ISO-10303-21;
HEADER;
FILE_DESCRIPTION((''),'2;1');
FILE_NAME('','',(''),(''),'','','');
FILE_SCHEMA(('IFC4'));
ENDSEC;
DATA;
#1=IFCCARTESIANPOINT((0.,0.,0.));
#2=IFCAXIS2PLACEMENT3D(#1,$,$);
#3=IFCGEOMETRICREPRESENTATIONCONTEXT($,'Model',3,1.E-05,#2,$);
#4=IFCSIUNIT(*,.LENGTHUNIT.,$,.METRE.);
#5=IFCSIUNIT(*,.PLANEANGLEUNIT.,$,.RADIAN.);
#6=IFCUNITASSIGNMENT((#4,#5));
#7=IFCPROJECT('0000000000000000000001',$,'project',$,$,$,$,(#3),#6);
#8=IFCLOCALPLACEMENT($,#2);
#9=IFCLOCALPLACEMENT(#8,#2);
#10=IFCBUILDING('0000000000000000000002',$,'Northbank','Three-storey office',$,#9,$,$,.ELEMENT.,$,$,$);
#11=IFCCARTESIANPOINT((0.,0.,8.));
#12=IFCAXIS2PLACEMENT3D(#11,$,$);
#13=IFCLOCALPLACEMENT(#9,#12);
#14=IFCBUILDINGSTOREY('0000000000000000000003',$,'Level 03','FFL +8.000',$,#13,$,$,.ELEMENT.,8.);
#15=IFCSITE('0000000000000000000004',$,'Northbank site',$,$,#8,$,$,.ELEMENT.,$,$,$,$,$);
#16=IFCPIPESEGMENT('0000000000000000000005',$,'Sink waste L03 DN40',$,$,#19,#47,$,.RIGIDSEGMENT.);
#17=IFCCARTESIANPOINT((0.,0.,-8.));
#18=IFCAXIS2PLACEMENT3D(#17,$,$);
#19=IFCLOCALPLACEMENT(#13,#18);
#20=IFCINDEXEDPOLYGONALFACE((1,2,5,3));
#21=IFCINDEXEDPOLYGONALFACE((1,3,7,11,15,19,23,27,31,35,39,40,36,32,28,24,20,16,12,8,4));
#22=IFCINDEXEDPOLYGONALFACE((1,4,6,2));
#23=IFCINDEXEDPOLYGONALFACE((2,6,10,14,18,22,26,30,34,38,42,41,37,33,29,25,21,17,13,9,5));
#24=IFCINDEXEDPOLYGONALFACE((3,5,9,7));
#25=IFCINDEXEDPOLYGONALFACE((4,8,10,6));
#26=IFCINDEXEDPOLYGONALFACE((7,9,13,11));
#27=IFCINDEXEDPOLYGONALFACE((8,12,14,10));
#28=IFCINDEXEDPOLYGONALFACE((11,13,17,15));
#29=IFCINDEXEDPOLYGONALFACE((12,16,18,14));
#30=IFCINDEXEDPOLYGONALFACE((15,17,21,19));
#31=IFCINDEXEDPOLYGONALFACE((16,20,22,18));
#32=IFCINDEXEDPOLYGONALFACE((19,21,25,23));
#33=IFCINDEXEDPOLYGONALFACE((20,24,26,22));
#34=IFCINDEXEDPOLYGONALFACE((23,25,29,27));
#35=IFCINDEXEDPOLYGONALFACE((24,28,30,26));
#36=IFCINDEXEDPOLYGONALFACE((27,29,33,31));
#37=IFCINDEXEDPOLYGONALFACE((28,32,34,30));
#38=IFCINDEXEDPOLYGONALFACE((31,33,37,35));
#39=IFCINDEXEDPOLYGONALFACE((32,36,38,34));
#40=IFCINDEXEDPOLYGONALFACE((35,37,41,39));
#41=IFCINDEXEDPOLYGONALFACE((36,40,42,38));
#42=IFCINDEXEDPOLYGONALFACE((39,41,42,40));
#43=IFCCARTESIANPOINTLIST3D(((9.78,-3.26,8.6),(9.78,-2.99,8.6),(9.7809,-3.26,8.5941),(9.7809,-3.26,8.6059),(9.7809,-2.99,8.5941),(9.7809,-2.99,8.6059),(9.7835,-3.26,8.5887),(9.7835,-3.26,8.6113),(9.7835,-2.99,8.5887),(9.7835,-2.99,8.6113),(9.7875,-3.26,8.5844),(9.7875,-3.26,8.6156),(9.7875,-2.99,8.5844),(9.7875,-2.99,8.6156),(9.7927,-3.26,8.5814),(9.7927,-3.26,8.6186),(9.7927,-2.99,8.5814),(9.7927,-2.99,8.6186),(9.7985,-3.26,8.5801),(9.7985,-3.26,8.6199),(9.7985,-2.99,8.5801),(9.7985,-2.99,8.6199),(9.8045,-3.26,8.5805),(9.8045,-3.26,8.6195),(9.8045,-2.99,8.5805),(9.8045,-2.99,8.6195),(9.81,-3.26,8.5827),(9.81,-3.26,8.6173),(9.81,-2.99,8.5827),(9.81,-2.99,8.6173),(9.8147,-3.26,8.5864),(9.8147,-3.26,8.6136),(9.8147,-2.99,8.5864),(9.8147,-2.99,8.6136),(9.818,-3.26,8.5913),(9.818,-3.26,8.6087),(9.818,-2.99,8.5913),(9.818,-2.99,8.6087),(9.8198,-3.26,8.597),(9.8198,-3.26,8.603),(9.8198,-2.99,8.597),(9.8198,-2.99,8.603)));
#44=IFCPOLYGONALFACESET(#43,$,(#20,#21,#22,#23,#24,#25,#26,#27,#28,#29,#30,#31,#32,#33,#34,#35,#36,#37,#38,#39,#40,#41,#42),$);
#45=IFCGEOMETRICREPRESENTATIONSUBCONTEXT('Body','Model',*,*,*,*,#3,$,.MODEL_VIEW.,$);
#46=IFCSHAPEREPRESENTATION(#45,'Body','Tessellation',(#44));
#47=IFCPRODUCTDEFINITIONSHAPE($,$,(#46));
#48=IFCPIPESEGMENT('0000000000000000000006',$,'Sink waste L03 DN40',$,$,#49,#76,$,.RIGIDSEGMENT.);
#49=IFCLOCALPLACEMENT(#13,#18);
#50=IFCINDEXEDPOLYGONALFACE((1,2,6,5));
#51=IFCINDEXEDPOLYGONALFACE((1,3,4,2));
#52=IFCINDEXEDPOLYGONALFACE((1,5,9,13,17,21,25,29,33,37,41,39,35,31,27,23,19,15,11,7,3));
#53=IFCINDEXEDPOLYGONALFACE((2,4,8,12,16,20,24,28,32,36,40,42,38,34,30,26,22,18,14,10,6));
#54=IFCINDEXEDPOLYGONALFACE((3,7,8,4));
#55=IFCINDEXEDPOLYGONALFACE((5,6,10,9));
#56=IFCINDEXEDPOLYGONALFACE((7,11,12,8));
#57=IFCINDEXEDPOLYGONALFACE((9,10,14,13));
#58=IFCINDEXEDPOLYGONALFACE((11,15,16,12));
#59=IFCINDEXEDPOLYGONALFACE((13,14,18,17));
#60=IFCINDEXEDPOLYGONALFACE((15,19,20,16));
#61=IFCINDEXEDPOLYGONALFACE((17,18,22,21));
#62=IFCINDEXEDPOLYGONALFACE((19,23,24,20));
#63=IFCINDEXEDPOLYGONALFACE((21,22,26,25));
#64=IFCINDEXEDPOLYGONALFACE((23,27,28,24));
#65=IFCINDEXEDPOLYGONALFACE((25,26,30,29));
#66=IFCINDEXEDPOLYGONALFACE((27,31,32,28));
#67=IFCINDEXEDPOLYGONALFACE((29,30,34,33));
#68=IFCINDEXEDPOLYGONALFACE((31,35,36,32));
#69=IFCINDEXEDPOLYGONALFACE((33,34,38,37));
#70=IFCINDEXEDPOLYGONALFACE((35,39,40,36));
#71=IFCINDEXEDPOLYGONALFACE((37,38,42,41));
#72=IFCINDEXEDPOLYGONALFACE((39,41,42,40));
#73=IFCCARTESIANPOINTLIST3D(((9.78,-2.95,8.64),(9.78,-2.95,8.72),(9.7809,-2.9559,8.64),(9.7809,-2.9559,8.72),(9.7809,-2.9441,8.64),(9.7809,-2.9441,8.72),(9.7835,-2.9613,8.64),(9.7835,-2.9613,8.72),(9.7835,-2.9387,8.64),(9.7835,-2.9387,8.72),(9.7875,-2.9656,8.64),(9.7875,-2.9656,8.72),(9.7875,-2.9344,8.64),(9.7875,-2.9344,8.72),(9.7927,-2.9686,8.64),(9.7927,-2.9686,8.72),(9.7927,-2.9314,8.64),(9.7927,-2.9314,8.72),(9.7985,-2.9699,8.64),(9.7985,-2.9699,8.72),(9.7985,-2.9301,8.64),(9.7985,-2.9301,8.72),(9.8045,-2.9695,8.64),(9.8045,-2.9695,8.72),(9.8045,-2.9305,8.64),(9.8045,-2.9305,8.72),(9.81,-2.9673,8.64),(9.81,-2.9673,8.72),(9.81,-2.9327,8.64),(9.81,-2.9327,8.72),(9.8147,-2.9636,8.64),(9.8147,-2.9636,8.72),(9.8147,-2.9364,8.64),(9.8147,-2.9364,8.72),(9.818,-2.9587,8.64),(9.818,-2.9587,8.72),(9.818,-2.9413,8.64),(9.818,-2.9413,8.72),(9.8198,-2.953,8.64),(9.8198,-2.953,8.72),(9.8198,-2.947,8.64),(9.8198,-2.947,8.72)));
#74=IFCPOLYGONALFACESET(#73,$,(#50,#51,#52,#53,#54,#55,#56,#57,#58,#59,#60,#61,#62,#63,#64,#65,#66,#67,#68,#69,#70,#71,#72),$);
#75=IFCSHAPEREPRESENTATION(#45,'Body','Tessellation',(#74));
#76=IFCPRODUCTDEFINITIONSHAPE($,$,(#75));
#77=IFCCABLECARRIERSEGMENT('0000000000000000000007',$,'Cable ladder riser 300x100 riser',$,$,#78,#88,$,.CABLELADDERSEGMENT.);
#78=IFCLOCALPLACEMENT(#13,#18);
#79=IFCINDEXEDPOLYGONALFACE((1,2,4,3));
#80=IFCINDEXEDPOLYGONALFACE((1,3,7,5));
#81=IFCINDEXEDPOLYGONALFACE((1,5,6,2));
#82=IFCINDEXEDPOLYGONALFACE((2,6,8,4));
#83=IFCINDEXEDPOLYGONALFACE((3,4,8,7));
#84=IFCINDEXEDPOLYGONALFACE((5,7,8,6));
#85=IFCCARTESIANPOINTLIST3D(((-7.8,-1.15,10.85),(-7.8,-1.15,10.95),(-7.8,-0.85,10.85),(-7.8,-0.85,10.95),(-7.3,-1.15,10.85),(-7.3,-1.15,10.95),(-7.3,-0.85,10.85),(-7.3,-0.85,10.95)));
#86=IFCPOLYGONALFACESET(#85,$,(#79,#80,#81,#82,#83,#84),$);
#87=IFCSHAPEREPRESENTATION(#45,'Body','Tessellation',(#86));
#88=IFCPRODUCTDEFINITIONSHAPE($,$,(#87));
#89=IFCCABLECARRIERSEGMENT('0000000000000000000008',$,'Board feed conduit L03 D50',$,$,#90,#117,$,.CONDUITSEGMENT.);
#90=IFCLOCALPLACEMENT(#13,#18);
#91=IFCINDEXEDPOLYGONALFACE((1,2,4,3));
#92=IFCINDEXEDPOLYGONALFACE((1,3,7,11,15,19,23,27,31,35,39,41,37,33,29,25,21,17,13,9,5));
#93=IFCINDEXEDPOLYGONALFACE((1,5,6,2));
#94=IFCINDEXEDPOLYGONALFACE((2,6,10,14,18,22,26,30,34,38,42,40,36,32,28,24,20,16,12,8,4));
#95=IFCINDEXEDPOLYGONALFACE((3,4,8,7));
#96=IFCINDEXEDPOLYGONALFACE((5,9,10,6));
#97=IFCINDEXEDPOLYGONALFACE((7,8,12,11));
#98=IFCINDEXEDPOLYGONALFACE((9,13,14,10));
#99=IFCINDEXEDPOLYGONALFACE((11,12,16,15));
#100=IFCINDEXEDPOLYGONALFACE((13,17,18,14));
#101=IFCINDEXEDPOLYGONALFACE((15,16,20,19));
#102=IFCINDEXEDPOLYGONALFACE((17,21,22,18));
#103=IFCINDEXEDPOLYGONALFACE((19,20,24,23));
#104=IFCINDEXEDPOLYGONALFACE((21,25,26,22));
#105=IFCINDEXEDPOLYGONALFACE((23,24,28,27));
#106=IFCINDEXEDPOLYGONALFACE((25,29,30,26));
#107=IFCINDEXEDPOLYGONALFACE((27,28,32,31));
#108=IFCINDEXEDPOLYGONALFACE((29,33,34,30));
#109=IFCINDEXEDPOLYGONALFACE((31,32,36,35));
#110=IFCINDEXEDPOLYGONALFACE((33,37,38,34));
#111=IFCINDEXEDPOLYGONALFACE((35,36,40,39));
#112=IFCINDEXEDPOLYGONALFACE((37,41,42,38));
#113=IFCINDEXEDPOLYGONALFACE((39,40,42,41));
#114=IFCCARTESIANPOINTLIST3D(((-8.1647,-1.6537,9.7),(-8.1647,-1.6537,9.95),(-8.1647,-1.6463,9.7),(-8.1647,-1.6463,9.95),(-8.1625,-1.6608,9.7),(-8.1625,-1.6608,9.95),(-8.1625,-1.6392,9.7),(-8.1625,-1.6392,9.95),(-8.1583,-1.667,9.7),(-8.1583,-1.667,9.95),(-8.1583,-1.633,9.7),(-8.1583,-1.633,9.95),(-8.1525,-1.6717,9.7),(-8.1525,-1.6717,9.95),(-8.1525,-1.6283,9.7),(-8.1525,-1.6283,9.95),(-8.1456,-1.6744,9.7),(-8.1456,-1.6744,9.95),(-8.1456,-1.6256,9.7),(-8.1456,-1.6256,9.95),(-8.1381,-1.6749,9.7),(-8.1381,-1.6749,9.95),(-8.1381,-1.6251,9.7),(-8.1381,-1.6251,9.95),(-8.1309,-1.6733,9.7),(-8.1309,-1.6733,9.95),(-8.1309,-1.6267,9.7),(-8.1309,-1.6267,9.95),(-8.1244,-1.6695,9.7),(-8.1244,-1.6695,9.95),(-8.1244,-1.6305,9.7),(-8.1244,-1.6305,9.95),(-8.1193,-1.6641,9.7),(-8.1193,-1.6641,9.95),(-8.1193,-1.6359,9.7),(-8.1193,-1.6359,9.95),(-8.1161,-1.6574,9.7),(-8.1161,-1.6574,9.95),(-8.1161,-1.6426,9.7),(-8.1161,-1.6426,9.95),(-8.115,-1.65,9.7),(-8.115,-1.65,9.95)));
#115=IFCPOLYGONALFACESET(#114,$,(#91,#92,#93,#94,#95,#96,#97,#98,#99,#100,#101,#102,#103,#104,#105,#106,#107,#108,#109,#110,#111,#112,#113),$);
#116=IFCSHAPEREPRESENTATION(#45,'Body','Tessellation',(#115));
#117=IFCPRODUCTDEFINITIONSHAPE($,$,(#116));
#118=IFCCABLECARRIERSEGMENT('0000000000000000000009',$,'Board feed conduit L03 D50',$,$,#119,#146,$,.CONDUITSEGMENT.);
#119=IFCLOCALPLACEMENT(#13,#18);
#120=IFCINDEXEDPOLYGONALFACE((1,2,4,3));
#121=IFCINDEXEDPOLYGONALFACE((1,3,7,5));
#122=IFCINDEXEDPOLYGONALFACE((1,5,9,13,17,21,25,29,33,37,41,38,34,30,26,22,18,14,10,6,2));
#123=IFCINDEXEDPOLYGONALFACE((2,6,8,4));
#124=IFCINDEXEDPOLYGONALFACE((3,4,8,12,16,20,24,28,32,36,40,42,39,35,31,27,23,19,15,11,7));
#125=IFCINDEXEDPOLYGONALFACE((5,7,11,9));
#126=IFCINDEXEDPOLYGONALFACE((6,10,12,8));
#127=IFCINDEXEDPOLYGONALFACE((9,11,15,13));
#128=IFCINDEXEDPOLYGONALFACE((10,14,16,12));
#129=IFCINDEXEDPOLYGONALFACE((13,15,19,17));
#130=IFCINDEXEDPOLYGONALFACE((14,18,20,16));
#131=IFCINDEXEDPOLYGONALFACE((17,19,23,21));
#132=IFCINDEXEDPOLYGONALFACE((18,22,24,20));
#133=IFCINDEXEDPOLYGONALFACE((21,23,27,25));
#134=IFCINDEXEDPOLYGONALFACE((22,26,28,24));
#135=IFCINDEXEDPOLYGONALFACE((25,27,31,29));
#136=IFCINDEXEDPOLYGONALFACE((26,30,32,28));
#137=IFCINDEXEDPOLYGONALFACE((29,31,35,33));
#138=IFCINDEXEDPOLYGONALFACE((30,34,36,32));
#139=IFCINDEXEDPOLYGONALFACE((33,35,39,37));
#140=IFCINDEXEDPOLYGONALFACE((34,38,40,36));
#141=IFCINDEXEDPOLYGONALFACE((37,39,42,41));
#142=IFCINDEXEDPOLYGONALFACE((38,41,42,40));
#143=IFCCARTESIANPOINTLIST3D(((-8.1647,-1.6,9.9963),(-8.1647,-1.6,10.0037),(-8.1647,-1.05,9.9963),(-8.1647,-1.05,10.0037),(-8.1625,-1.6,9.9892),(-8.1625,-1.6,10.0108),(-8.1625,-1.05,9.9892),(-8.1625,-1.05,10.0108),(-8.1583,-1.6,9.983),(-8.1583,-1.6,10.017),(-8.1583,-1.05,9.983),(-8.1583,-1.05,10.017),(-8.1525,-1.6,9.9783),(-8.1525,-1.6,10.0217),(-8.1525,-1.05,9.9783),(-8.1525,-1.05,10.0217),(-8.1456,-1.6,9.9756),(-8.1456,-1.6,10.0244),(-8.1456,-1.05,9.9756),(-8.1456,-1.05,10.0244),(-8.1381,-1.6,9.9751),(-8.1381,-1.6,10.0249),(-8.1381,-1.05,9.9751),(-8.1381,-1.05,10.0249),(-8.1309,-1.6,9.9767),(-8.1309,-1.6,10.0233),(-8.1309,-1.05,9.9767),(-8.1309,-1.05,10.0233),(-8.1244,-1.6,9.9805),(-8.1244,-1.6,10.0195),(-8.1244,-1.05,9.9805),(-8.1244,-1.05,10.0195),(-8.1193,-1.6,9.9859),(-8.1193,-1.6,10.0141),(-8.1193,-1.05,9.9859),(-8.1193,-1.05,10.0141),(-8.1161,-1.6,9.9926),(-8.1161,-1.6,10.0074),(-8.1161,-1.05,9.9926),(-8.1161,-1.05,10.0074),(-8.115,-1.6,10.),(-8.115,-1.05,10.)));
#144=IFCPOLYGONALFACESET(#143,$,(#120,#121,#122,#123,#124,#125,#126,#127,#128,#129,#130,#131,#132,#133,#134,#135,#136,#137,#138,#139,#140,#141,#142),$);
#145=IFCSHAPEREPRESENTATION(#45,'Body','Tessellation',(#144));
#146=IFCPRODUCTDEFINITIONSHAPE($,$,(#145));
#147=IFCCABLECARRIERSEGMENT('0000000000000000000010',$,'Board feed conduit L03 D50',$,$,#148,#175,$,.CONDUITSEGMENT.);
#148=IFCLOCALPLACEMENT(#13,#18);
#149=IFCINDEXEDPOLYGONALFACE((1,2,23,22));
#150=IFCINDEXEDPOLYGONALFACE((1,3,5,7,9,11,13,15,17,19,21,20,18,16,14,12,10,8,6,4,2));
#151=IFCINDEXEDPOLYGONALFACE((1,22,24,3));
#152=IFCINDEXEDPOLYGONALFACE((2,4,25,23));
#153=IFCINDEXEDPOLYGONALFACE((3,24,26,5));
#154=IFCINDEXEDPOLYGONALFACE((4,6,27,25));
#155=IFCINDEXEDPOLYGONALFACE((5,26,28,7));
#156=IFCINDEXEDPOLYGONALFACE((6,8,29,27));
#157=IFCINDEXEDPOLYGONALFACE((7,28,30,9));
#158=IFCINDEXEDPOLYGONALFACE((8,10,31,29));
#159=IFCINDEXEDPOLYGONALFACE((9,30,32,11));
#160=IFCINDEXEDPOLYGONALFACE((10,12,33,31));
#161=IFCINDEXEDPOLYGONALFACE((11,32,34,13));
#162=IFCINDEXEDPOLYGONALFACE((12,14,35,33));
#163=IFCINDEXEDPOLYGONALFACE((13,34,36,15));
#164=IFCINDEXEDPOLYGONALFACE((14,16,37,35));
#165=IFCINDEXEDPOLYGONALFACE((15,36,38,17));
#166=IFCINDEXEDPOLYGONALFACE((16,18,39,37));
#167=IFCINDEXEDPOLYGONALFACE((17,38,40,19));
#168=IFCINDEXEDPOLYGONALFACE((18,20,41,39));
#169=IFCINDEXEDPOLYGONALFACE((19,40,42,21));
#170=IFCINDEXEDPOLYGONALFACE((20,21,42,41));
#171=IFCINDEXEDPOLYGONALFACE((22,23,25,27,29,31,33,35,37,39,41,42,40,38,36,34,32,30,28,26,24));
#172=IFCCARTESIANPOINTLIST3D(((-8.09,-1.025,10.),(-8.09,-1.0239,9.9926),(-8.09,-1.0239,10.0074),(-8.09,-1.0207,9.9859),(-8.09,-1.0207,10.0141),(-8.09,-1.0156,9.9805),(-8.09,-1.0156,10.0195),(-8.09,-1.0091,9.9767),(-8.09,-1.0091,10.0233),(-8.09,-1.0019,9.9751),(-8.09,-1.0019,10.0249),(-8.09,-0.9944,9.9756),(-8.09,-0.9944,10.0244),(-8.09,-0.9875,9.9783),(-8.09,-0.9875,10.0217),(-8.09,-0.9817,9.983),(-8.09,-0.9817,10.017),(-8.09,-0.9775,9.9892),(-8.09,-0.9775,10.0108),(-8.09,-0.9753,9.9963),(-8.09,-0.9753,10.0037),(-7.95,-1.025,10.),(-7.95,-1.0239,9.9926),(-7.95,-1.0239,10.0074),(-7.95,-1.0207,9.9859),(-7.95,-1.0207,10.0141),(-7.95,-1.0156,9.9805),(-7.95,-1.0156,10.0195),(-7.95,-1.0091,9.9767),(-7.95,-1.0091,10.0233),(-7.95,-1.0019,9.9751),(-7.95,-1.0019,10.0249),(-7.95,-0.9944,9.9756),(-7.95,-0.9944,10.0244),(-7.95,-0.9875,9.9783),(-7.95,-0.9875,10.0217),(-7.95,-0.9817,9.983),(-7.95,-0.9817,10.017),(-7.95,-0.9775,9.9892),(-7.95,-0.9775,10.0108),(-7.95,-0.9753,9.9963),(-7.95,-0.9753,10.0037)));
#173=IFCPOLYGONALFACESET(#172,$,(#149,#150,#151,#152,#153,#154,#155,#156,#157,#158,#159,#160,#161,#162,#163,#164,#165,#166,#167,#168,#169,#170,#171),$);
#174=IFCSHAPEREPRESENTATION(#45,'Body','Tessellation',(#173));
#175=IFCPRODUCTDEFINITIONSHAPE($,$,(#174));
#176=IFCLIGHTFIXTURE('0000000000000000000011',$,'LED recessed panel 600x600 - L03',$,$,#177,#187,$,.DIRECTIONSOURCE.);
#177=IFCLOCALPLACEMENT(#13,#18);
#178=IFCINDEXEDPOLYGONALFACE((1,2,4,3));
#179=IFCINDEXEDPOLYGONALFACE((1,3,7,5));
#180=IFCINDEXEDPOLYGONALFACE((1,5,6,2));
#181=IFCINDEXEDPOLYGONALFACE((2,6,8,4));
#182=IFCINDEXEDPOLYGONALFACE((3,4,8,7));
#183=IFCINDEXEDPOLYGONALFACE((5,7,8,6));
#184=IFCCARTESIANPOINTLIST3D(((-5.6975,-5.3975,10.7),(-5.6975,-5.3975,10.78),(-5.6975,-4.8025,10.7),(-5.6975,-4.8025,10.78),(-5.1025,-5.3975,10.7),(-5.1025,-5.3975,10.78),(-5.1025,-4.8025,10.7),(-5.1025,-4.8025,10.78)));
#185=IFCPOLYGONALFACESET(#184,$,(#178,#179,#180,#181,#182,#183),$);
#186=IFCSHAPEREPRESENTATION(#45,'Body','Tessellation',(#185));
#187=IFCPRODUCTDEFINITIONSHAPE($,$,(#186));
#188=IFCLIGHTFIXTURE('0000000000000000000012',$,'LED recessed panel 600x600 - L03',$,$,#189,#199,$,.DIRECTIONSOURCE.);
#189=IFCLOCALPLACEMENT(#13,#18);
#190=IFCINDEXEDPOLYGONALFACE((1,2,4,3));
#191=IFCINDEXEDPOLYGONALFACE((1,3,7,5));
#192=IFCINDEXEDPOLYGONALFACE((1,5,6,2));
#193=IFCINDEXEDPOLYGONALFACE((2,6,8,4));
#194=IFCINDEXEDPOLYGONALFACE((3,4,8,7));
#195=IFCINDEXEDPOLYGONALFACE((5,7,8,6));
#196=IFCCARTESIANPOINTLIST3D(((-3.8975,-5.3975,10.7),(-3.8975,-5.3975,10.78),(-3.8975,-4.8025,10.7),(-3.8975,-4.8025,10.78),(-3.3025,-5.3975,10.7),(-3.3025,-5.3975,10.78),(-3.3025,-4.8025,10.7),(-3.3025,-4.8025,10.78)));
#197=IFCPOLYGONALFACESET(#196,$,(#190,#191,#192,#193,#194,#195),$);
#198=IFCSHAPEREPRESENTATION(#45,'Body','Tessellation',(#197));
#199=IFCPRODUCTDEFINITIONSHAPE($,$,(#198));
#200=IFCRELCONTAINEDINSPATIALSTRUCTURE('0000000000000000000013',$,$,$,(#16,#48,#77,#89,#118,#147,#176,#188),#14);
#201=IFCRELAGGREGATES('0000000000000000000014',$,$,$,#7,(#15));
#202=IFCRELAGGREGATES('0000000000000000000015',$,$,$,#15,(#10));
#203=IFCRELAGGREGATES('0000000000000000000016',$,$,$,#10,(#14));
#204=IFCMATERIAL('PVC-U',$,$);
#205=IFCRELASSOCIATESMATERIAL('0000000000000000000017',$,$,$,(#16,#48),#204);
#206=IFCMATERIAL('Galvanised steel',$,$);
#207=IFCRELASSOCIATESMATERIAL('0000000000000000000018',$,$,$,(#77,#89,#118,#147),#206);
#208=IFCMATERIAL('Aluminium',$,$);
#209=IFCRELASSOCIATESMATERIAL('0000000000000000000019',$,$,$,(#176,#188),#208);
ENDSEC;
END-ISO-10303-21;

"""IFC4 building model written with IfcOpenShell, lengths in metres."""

from ifc_helpers import new_model, si_unit, frame, origin, place, context, subcontext, project, spatial, rectangle, circle, extrude, material, element, save


model = new_model("IFC4")

# Units and contexts
model_context = context("Model", 3, precision=1e-05, world=origin())
body_context = subcontext(model_context, "Body", "Model", "MODEL_VIEW")
ifc_project = project(units=[si_unit("LENGTHUNIT", "METRE"), si_unit("PLANEANGLEUNIT", "RADIAN")], contexts=[model_context])

# Site, building, storey
site_placement = place(None, origin())
site = spatial("IfcSite", under=ifc_project, at=site_placement, Name="Northbank site", CompositionType="ELEMENT")
building_placement = place(site_placement, origin())
building = spatial("IfcBuilding", under=site, at=building_placement, Name="Northbank", Description="Three-storey office", CompositionType="ELEMENT")
storey_placement = place(building_placement, frame((0.0, 0.0, 8.0)))
storey = spatial("IfcBuildingStorey", under=building, at=storey_placement, Name="Level 03", Description="FFL +8.000", CompositionType="ELEMENT", Elevation=8.0)

# Shared definitions
ifc_material_1 = material(Name="PVC-U")

# Pipe segments
pipe_segment_1_placement = place(storey_placement, frame((0.0, 0.0, -8.0)))
element("IfcPipeSegment", 1, at=pipe_segment_1_placement, inside=storey, material=ifc_material_1, Name="Sink waste L03 DN40", PredefinedType="RIGIDSEGMENT", context=body_context, shape_type="SweptSolid", body=[
    extrude(circle(Radius=0.02), frame((9.8, -3.26, 8.6), z_axis=(0.0, 1.0, 0.0), x_axis=(-1.0, 0.0, 0.0)), (0.0, 0.0, 1.0), 0.27),
])
pipe_segment_2_placement = place(storey_placement, frame((0.0, 0.0, -8.0)))
element("IfcPipeSegment", 2, at=pipe_segment_2_placement, inside=storey, material=ifc_material_1, Name="Sink waste L03 DN40", PredefinedType="RIGIDSEGMENT", context=body_context, shape_type="SweptSolid", body=[
    extrude(circle(Radius=0.02), frame((9.8, -2.95, 8.64), z_axis=(0.0, 0.0, 1.0), x_axis=(-1.0, 0.0, 0.0)), (0.0, 0.0, 1.0), 0.08),
])

# Cable carrier segments
ifc_material_2 = material(Name="Galvanised steel")
cable_carrier_segment_1_placement = place(storey_placement, frame((0.0, 0.0, -8.0)))
element("IfcCableCarrierSegment", 3, at=cable_carrier_segment_1_placement, inside=storey, material=ifc_material_2, Name="Cable ladder riser 300x100 riser", PredefinedType="CABLELADDERSEGMENT", context=body_context, shape_type="SweptSolid", body=[
    extrude(rectangle(XDim=0.1, YDim=0.3), frame((-7.8, -1.0, 10.9), z_axis=(1.0, 0.0, 0.0), x_axis=(0.0, 0.0, -1.0)), (0.0, 0.0, 1.0), 0.5),
])
cable_carrier_segment_2_placement = place(storey_placement, frame((0.0, 0.0, -8.0)))
element("IfcCableCarrierSegment", 4, at=cable_carrier_segment_2_placement, inside=storey, material=ifc_material_2, Name="Board feed conduit L03 D50", PredefinedType="CONDUITSEGMENT", context=body_context, shape_type="SweptSolid", body=[
    extrude(circle(Radius=0.025), frame((-8.14, -1.65, 9.7), z_axis=(0.0, 0.0, 1.0), x_axis=(1.0, 0.0, 0.0)), (0.0, 0.0, 1.0), 0.25),
])
cable_carrier_segment_3_placement = place(storey_placement, frame((0.0, 0.0, -8.0)))
element("IfcCableCarrierSegment", 5, at=cable_carrier_segment_3_placement, inside=storey, material=ifc_material_2, Name="Board feed conduit L03 D50", PredefinedType="CONDUITSEGMENT", context=body_context, shape_type="SweptSolid", body=[
    extrude(circle(Radius=0.025), frame((-8.14, -1.6, 10.0), z_axis=(0.0, 1.0, 0.0), x_axis=(1.0, 0.0, 0.0)), (0.0, 0.0, 1.0), 0.55),
])
cable_carrier_segment_4_placement = place(storey_placement, frame((0.0, 0.0, -8.0)))
element("IfcCableCarrierSegment", 6, at=cable_carrier_segment_4_placement, inside=storey, material=ifc_material_2, Name="Board feed conduit L03 D50", PredefinedType="CONDUITSEGMENT", context=body_context, shape_type="SweptSolid", body=[
    extrude(circle(Radius=0.025), frame((-8.09, -1.0, 10.0), z_axis=(1.0, 0.0, 0.0), x_axis=(0.0, -1.0, 0.0)), (0.0, 0.0, 1.0), 0.14),
])

# Light fixtures
ifc_material_3 = material(Name="Aluminium")
light_fixture_1_placement = place(storey_placement, frame((0.0, 0.0, -8.0)))
element("IfcLightFixture", 7, at=light_fixture_1_placement, inside=storey, material=ifc_material_3, Name="LED recessed panel 600x600 - L03", PredefinedType="DIRECTIONSOURCE", context=body_context, shape_type="SweptSolid", body=[
    extrude(rectangle(XDim=0.595, YDim=0.595), frame((-5.4, -5.1, 10.7)), (0.0, 0.0, 1.0), 0.08),
])
light_fixture_2_placement = place(storey_placement, frame((0.0, 0.0, -8.0)))
element("IfcLightFixture", 8, at=light_fixture_2_placement, inside=storey, material=ifc_material_3, Name="LED recessed panel 600x600 - L03", PredefinedType="DIRECTIONSOURCE", context=body_context, shape_type="SweptSolid", body=[
    extrude(rectangle(XDim=0.595, YDim=0.595), frame((-3.6, -5.1, 10.7)), (0.0, 0.0, 1.0), 0.08),
])

save(model, "model.ifc")
